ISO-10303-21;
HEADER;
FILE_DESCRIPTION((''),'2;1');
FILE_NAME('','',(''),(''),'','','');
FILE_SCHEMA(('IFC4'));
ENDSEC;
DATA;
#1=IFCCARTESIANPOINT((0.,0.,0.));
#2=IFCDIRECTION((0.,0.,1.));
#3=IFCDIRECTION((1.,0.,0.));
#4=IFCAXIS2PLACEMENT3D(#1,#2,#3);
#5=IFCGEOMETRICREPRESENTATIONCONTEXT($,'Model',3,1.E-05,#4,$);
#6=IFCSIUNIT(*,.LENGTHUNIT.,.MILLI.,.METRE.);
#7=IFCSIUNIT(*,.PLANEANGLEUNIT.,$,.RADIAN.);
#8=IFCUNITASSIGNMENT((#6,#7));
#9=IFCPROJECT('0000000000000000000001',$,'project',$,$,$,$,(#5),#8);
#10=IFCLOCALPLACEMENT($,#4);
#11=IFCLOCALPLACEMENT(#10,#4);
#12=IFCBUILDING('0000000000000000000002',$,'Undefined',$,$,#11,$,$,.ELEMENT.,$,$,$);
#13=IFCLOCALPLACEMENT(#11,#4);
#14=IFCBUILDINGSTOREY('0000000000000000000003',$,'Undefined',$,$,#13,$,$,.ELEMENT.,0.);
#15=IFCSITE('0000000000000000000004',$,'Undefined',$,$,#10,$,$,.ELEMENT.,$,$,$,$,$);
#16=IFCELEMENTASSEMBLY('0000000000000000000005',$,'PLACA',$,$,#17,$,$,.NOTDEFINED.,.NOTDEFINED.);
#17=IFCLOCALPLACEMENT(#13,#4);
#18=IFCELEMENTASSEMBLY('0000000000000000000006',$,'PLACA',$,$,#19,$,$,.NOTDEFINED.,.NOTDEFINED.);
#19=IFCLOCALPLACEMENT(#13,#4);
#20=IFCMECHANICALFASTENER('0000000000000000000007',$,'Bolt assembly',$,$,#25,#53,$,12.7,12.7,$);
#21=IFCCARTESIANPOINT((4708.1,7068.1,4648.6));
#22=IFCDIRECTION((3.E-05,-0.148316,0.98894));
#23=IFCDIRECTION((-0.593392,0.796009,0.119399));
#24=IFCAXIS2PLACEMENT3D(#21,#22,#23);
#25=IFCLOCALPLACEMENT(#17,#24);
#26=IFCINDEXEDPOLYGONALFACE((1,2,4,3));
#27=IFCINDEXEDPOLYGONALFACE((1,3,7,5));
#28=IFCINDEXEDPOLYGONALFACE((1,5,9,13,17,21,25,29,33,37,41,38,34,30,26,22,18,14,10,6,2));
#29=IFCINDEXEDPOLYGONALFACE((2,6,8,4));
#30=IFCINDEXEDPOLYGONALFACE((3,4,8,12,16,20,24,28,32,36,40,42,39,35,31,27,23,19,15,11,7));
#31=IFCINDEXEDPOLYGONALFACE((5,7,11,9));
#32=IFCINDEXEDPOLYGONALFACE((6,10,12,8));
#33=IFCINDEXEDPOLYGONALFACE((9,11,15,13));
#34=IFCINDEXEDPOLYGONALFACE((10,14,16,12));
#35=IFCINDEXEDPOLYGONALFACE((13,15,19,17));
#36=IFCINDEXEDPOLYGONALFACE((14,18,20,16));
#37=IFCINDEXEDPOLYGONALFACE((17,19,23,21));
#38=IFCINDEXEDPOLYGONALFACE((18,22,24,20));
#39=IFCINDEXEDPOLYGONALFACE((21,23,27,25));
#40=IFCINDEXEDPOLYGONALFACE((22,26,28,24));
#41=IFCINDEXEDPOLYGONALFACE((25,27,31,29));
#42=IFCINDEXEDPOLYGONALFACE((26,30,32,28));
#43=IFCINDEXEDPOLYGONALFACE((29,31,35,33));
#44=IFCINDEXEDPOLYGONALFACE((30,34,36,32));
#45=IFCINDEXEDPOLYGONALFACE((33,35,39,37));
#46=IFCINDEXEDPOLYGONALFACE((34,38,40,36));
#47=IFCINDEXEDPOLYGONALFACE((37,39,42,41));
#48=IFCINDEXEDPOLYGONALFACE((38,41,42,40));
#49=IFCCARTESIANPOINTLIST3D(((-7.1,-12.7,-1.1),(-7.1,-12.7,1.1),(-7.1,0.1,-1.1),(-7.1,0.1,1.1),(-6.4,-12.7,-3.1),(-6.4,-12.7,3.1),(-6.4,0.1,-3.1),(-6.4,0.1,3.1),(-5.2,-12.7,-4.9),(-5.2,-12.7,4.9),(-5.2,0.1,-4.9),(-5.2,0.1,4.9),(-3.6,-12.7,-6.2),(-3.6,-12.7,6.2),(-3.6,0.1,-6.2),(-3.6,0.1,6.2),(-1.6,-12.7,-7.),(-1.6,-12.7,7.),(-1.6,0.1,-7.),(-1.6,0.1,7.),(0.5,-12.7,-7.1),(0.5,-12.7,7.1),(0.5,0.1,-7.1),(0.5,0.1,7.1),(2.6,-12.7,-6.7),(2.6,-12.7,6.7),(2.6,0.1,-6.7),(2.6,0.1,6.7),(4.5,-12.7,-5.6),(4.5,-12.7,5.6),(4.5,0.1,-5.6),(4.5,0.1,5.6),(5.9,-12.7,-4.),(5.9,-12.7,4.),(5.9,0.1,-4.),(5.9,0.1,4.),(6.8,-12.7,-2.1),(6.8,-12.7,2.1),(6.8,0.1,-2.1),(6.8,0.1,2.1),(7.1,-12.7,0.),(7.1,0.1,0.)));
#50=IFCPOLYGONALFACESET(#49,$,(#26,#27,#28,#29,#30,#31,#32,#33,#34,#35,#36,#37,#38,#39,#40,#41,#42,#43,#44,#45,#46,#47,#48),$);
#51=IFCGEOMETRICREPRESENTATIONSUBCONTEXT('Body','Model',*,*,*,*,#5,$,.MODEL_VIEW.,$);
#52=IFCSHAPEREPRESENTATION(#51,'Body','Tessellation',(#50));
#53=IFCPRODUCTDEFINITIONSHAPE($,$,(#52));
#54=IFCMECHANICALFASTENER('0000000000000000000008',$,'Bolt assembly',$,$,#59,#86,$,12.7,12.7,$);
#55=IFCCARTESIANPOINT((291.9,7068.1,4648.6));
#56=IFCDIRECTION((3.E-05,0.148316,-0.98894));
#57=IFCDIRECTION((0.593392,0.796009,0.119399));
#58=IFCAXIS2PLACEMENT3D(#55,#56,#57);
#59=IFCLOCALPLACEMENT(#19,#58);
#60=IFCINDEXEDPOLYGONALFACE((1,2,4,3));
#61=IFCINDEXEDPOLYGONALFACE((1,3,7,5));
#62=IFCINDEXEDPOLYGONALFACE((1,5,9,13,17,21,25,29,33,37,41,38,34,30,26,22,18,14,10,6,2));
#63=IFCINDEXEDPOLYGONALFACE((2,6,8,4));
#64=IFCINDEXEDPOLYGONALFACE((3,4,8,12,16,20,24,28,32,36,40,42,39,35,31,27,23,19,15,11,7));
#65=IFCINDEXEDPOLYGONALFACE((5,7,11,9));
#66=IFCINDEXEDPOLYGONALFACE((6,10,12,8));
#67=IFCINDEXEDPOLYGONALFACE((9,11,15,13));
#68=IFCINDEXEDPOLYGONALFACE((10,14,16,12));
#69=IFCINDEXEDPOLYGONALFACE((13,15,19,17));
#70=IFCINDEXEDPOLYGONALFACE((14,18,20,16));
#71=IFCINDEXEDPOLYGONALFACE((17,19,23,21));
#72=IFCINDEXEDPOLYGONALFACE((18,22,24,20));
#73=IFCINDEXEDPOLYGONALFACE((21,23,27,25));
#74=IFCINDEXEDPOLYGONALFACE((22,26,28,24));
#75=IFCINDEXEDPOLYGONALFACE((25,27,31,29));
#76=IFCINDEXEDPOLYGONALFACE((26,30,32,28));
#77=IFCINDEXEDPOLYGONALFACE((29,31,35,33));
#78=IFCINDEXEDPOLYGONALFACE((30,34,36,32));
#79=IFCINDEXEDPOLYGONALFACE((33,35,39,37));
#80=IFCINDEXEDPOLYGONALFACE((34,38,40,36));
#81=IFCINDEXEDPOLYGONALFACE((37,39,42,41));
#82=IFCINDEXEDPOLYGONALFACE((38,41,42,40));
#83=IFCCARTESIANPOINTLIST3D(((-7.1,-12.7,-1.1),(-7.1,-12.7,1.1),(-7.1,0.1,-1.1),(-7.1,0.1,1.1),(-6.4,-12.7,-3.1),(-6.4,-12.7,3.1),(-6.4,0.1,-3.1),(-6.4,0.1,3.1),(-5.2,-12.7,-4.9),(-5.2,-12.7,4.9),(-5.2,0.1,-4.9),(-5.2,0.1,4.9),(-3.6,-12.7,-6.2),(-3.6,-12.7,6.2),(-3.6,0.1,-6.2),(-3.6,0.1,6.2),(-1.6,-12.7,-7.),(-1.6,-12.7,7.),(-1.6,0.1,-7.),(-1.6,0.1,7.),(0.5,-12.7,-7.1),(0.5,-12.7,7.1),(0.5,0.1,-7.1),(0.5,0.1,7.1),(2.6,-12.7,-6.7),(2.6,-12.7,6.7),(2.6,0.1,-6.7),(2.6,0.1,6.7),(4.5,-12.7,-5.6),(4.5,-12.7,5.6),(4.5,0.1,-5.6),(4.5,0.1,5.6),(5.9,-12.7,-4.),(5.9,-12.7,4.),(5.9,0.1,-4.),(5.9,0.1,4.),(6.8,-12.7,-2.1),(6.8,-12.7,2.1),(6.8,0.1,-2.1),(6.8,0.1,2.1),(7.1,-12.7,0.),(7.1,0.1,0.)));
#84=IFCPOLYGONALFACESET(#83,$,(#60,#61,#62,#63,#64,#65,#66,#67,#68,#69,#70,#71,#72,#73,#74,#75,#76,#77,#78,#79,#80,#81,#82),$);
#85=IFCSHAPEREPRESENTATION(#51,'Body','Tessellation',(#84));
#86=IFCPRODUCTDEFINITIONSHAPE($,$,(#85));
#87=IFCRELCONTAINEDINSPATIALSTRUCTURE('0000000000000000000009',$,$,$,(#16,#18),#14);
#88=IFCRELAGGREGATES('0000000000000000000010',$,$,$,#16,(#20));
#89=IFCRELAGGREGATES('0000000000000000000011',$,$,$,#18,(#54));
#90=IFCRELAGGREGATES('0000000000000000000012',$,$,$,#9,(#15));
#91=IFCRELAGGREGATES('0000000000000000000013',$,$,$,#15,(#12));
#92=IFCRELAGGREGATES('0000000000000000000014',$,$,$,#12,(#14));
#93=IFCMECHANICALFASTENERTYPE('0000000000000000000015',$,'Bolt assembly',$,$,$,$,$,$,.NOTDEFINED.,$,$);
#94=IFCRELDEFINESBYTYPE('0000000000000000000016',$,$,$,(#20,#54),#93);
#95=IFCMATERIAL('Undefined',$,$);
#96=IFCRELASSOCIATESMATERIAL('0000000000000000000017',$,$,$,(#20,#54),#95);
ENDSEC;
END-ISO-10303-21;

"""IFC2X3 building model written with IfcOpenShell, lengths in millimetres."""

from ifc_helpers import new_model, si_unit, frame, origin_with_axes, origin_2d_with_axis, place, context, subcontext, project, spatial, circle, extrude, source, transform, mapped, material, type_object, element, aggregate, save


model = new_model("IFC2X3")

# Units and contexts
model_context = context("Model", 3, precision=1e-05, world=origin_with_axes())
body_context = subcontext(model_context, "Body", "Model", "MODEL_VIEW")
ifc_project = project(units=[si_unit("LENGTHUNIT", "METRE", prefix="MILLI"), si_unit("PLANEANGLEUNIT", "RADIAN")], contexts=[model_context])

# Site, building, storey
site_placement = place(None, origin_with_axes())
site = spatial("IfcSite", under=ifc_project, at=site_placement, Name="Undefined", CompositionType="ELEMENT")
building_placement = place(site_placement, origin_with_axes())
building = spatial("IfcBuilding", under=site, at=building_placement, Name="Undefined", CompositionType="ELEMENT")
storey_placement = place(building_placement, origin_with_axes())
storey = spatial("IfcBuildingStorey", under=building, at=storey_placement, Name="Undefined", CompositionType="ELEMENT", Elevation=0.0)

# Element assemblies
assembly_1_placement = place(storey_placement, origin_with_axes())
assembly_1 = element("IfcElementAssembly", 1, at=assembly_1_placement, inside=storey, Name="PLACA", AssemblyPlace="NOTDEFINED", PredefinedType="NOTDEFINED")
assembly_2_placement = place(storey_placement, origin_with_axes())
assembly_2 = element("IfcElementAssembly", 2, at=assembly_2_placement, inside=storey, Name="PLACA", AssemblyPlace="NOTDEFINED", PredefinedType="NOTDEFINED")

# Mechanical fasteners
ifc_material_1 = material(Name="Undefined")
mechanical_fastener_type = type_object("IfcMechanicalFastenerType", Name="Bolt assembly")
shared_shape_1 = source(origin_with_axes(), body_context, "Body", "SweptSolid", [
    extrude(circle(Radius=7.1, at=origin_2d_with_axis()), frame((0.0, -12.7, 0.0), z_axis=(0.0, 1.0, 0.0), x_axis=(1.0, 0.0, 0.0)), (0.0, 0.0, 1.0), 12.8),
])
mechanical_fastener_1_placement = place(assembly_1_placement, frame((4708.1, 7068.1, 4648.6), z_axis=(0.00003, -0.148316, 0.98894), x_axis=(-0.593392, 0.796009, 0.119399)))
mechanical_fastener_1 = element("IfcMechanicalFastener", 3, at=mechanical_fastener_1_placement, type_object=mechanical_fastener_type, material=ifc_material_1, Name="Bolt assembly", NominalDiameter=12.7, NominalLength=12.7, context=body_context, shape_type="MappedRepresentation", body=[
    mapped(shared_shape_1, transform((0.0, 0.0, 0.0))),
])
aggregate(assembly_1, [mechanical_fastener_1])
mechanical_fastener_2_placement = place(assembly_2_placement, frame((291.9, 7068.1, 4648.6), z_axis=(0.00003, 0.148316, -0.98894), x_axis=(0.593392, 0.796009, 0.119399)))
mechanical_fastener_2 = element("IfcMechanicalFastener", 4, at=mechanical_fastener_2_placement, type_object=mechanical_fastener_type, material=ifc_material_1, Name="Bolt assembly", NominalDiameter=12.7, NominalLength=12.7, context=body_context, shape_type="MappedRepresentation", body=[
    mapped(shared_shape_1, transform((0.0, 0.0, 0.0))),
])
aggregate(assembly_2, [mechanical_fastener_2])

save(model, "model.ifc")
